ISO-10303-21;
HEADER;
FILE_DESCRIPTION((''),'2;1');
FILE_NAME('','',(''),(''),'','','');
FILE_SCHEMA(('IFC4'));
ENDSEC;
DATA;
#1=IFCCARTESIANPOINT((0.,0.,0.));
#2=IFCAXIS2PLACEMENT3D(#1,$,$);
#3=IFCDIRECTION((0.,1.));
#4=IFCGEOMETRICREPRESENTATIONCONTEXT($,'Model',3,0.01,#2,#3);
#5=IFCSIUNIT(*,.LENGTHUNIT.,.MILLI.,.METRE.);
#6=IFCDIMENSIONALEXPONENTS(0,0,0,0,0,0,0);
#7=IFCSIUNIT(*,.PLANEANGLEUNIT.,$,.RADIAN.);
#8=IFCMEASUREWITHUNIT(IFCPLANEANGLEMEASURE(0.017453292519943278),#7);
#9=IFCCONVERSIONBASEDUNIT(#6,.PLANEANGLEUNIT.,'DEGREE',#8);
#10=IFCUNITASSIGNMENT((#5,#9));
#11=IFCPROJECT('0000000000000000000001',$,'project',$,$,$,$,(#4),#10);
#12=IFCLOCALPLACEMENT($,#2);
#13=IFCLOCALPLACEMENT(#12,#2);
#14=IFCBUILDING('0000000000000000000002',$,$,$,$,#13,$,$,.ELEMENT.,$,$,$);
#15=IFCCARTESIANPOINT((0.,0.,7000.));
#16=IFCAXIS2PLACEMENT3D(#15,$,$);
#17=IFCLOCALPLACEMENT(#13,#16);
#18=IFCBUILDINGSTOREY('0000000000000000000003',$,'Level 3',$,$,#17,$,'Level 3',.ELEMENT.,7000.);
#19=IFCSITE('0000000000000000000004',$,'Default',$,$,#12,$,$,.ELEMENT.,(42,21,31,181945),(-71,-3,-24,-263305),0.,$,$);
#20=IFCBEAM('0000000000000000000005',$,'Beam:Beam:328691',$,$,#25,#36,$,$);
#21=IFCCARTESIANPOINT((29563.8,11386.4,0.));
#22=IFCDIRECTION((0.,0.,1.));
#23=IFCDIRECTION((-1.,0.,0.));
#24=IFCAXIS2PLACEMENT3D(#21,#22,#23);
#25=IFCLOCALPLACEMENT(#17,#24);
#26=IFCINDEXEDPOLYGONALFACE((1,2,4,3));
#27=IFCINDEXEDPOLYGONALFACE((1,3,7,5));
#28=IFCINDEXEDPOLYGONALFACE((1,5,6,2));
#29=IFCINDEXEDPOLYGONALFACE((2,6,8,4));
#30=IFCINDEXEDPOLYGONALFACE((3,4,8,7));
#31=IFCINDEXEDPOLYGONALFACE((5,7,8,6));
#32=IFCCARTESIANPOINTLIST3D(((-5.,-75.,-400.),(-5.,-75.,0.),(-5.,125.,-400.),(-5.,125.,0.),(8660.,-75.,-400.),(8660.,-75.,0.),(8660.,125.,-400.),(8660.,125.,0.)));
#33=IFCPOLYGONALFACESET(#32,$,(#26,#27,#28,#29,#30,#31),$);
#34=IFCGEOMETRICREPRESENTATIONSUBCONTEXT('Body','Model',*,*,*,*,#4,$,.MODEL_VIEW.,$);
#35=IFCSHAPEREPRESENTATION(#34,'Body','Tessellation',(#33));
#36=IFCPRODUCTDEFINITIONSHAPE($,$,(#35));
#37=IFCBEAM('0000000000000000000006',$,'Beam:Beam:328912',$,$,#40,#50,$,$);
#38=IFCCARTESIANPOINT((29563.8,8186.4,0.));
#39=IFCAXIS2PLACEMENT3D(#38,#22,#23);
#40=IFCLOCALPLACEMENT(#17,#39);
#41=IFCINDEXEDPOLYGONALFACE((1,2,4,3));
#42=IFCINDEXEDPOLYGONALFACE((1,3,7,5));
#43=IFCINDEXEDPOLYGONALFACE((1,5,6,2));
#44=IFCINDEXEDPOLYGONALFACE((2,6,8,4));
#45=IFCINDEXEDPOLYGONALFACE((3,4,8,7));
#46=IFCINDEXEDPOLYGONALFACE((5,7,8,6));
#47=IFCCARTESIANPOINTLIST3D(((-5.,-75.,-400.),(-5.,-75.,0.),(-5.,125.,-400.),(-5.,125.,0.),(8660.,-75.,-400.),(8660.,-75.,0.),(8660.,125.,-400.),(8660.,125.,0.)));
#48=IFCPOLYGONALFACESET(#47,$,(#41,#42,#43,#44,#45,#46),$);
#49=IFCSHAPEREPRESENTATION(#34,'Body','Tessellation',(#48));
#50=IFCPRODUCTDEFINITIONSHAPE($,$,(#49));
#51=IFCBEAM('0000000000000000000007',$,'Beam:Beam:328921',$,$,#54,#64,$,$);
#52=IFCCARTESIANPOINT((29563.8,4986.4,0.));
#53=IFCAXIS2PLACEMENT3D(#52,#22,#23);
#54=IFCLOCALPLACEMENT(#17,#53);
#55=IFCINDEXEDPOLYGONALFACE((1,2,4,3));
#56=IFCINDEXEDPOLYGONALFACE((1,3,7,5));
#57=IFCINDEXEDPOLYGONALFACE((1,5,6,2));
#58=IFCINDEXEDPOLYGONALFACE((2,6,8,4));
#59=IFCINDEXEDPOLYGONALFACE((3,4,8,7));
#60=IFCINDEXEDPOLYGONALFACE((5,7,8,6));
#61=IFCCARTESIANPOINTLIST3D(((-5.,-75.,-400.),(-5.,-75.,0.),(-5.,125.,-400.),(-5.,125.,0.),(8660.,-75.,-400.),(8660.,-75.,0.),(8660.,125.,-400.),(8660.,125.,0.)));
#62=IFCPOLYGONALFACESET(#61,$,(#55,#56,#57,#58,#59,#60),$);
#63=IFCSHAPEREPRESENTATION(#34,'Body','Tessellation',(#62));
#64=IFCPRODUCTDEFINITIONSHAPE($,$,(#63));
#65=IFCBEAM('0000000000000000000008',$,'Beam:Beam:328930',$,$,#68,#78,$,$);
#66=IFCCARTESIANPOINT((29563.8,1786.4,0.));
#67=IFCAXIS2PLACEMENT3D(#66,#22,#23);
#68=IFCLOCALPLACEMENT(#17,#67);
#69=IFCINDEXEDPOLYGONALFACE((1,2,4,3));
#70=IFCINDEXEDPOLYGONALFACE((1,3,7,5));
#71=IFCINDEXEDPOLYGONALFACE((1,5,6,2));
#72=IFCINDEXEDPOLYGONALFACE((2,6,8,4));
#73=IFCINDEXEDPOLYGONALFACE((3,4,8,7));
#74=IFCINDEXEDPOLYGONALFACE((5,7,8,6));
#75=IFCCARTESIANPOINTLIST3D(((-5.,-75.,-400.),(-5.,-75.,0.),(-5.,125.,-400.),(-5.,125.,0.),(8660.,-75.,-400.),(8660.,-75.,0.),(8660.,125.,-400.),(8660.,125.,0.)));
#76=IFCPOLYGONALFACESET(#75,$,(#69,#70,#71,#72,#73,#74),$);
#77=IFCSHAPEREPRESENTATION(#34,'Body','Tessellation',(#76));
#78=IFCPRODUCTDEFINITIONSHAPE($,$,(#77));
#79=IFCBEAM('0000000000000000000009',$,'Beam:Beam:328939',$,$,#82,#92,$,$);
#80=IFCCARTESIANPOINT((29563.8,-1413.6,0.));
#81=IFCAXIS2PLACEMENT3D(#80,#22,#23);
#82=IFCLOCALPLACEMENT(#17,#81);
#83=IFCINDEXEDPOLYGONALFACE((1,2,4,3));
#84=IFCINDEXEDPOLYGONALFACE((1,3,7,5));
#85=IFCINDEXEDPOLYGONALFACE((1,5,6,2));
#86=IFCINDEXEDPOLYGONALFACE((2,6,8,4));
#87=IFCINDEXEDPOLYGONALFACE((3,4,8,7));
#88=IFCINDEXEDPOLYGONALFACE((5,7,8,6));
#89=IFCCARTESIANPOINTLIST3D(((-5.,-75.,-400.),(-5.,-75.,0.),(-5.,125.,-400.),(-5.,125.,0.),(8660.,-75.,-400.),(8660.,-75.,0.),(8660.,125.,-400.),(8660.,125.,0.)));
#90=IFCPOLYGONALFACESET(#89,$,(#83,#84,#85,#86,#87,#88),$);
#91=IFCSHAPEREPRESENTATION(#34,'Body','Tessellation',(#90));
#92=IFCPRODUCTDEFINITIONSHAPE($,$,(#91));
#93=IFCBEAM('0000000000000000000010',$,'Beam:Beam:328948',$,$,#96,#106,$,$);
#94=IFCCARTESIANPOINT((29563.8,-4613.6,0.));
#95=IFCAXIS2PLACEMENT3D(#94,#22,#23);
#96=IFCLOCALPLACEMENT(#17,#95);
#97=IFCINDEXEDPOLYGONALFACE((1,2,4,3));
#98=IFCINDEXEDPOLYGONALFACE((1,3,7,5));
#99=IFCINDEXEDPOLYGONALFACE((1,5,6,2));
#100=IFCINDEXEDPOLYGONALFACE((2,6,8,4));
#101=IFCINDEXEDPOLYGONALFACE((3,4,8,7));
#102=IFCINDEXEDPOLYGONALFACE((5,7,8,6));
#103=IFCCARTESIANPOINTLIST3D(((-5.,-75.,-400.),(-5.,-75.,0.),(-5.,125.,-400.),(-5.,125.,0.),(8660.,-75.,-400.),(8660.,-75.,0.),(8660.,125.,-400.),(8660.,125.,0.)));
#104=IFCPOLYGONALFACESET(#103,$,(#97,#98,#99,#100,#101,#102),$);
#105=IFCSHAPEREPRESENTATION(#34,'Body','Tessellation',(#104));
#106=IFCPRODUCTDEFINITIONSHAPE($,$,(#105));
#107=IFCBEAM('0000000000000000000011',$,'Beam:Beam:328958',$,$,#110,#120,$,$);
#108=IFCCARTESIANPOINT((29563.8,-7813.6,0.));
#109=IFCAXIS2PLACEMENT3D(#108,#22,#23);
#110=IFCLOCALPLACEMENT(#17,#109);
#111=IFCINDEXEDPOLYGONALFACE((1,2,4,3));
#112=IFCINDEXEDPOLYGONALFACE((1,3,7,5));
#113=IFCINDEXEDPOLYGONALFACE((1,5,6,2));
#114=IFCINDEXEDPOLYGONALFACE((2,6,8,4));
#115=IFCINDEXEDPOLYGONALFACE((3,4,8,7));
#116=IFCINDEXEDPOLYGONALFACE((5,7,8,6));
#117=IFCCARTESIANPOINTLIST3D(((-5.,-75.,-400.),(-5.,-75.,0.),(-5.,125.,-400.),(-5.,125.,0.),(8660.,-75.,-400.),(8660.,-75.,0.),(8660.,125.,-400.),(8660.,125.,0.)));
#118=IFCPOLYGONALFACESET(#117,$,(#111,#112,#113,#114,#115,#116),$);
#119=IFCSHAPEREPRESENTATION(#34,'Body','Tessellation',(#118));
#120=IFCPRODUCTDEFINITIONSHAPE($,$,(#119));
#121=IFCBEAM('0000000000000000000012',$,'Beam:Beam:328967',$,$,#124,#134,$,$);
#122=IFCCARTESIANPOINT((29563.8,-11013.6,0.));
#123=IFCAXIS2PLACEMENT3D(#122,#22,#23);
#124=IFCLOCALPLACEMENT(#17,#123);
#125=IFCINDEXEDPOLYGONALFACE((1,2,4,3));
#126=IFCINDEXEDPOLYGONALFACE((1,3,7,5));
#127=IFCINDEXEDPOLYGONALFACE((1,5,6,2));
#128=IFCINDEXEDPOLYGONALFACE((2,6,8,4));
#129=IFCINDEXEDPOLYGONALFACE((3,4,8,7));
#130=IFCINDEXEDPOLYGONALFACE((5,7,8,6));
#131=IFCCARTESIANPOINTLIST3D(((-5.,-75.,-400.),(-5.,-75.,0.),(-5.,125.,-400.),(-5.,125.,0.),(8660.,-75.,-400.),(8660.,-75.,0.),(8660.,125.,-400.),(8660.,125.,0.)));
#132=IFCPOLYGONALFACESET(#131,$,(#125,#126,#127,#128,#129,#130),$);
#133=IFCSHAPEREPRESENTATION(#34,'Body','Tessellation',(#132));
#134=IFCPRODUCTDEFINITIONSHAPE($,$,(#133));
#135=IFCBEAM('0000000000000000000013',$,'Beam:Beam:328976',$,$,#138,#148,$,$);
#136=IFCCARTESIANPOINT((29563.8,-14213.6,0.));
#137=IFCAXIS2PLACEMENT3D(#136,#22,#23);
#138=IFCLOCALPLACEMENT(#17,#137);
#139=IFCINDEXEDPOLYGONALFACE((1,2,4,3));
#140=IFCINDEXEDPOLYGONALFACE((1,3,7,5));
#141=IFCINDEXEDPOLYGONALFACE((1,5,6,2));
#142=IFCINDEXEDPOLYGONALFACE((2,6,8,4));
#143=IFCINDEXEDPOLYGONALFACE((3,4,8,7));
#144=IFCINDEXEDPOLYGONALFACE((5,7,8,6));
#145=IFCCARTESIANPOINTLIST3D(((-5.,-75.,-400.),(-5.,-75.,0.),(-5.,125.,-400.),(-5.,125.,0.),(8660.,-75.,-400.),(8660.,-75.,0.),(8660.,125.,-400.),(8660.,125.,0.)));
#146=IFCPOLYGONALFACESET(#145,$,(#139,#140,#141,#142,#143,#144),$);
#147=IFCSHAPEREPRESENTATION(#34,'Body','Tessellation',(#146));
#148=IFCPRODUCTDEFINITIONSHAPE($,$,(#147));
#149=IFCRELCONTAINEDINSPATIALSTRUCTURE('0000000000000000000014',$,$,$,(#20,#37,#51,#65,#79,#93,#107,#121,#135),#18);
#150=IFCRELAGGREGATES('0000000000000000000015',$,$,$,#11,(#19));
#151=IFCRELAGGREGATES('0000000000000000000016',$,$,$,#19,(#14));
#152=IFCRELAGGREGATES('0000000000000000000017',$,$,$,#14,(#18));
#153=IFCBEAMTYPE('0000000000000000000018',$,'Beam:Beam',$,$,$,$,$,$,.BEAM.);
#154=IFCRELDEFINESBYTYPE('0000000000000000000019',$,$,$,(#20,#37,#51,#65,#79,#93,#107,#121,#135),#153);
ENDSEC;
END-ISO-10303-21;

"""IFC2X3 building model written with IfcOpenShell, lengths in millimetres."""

from ifc_helpers import new_model, entity, si_unit, converted_unit, direction, frame, frame_2d, origin, origin_2d_with_axis, place, context, subcontext, project, spatial, rectangle, extrude, type_object, element, save


model = new_model("IFC2X3")

# Units and contexts
model_context = context("Model", 3, precision=0.01, world=origin(), true_north=direction((0.0, 1.0)))
body_context = subcontext(model_context, "Body", "Model", "MODEL_VIEW")
ifc_project = project(units=[si_unit("LENGTHUNIT", "METRE", prefix="MILLI"), converted_unit("PLANEANGLEUNIT", "DEGREE", entity("IfcPlaneAngleMeasure", 0.017453292519943278), si_unit("PLANEANGLEUNIT", "RADIAN"), dimensions=[0, 0, 0, 0, 0, 0, 0])], contexts=[model_context])

# Site, building, storey
site_placement = place(None, origin())
site = spatial("IfcSite", under=ifc_project, at=site_placement, Name="Default", CompositionType="ELEMENT", RefLatitude=(42, 21, 31, 181945), RefLongitude=(-71, -3, -24, -263305), RefElevation=0.0)
building_placement = place(site_placement, origin())
building = spatial("IfcBuilding", under=site, at=building_placement, CompositionType="ELEMENT")
storey_placement = place(building_placement, frame((0.0, 0.0, 7000.0)))
storey = spatial("IfcBuildingStorey", under=building, at=storey_placement, Name="Level 3", LongName="Level 3", CompositionType="ELEMENT", Elevation=7000.0)

# Beams
beam_type = type_object("IfcBeamType", Name="Beam:Beam", PredefinedType="BEAM")
beam_1_placement = place(storey_placement, frame((29563.8, 11386.4, 0.0), z_axis=(0.0, 0.0, 1.0), x_axis=(-1.0, 0.0, 0.0)))
element("IfcBeam", 1, at=beam_1_placement, inside=storey, type_object=beam_type, Name="Beam:Beam:328691", context=body_context, shape_type="SweptSolid", body=[
    extrude(rectangle(XDim=400.0, YDim=200.0, at=frame_2d((0.0, 0.0), x_axis=(1.0, 0.0))), frame((-5.0, 25.0, -200.0), z_axis=(1.0, 0.0, 0.0), x_axis=(0.0, 0.0, -1.0)), (0.0, 0.0, 1.0), 8665.0),
])
beam_2_placement = place(storey_placement, frame((29563.8, 8186.4, 0.0), z_axis=(0.0, 0.0, 1.0), x_axis=(-1.0, 0.0, 0.0)))
element("IfcBeam", 2, at=beam_2_placement, inside=storey, type_object=beam_type, Name="Beam:Beam:328912", context=body_context, shape_type="SweptSolid", body=[
    extrude(rectangle(XDim=400.0, YDim=200.0, at=origin_2d_with_axis()), frame((-5.0, 25.0, -200.0), z_axis=(1.0, 0.0, 0.0), x_axis=(0.0, 0.0, -1.0)), (0.0, 0.0, 1.0), 8665.0),
])
beam_3_placement = place(storey_placement, frame((29563.8, 4986.4, 0.0), z_axis=(0.0, 0.0, 1.0), x_axis=(-1.0, 0.0, 0.0)))
element("IfcBeam", 3, at=beam_3_placement, inside=storey, type_object=beam_type, Name="Beam:Beam:328921", context=body_context, shape_type="SweptSolid", body=[
    extrude(rectangle(XDim=400.0, YDim=200.0, at=origin_2d_with_axis()), frame((-5.0, 25.0, -200.0), z_axis=(1.0, 0.0, 0.0), x_axis=(0.0, 0.0, -1.0)), (0.0, 0.0, 1.0), 8665.0),
])
beam_4_placement = place(storey_placement, frame((29563.8, 1786.4, 0.0), z_axis=(0.0, 0.0, 1.0), x_axis=(-1.0, 0.0, 0.0)))
element("IfcBeam", 4, at=beam_4_placement, inside=storey, type_object=beam_type, Name="Beam:Beam:328930", context=body_context, shape_type="SweptSolid", body=[
    extrude(rectangle(XDim=400.0, YDim=200.0, at=frame_2d((0.0, 0.0), x_axis=(1.0, 0.0))), frame((-5.0, 25.0, -200.0), z_axis=(1.0, 0.0, 0.0), x_axis=(0.0, 0.0, -1.0)), (0.0, 0.0, 1.0), 8665.0),
])
beam_5_placement = place(storey_placement, frame((29563.8, -1413.6, 0.0), z_axis=(0.0, 0.0, 1.0), x_axis=(-1.0, 0.0, 0.0)))
element("IfcBeam", 5, at=beam_5_placement, inside=storey, type_object=beam_type, Name="Beam:Beam:328939", context=body_context, shape_type="SweptSolid", body=[
    extrude(rectangle(XDim=400.0, YDim=200.0, at=frame_2d((0.0, 0.0), x_axis=(1.0, 0.0))), frame((-5.0, 25.0, -200.0), z_axis=(1.0, 0.0, 0.0), x_axis=(0.0, 0.0, -1.0)), (0.0, 0.0, 1.0), 8665.0),
])
beam_6_placement = place(storey_placement, frame((29563.8, -4613.6, 0.0), z_axis=(0.0, 0.0, 1.0), x_axis=(-1.0, 0.0, 0.0)))
element("IfcBeam", 6, at=beam_6_placement, inside=storey, type_object=beam_type, Name="Beam:Beam:328948", context=body_context, shape_type="SweptSolid", body=[
    extrude(rectangle(XDim=400.0, YDim=200.0, at=frame_2d((0.0, 0.0), x_axis=(1.0, 0.0))), frame((-5.0, 25.0, -200.0), z_axis=(1.0, 0.0, 0.0), x_axis=(0.0, 0.0, -1.0)), (0.0, 0.0, 1.0), 8665.0),
])
beam_7_placement = place(storey_placement, frame((29563.8, -7813.6, 0.0), z_axis=(0.0, 0.0, 1.0), x_axis=(-1.0, 0.0, 0.0)))
element("IfcBeam", 7, at=beam_7_placement, inside=storey, type_object=beam_type, Name="Beam:Beam:328958", context=body_context, shape_type="SweptSolid", body=[
    extrude(rectangle(XDim=400.0, YDim=200.0, at=frame_2d((0.0, 0.0), x_axis=(1.0, 0.0))), frame((-5.0, 25.0, -200.0), z_axis=(1.0, 0.0, 0.0), x_axis=(0.0, 0.0, -1.0)), (0.0, 0.0, 1.0), 8665.0),
])
beam_8_placement = place(storey_placement, frame((29563.8, -11013.6, 0.0), z_axis=(0.0, 0.0, 1.0), x_axis=(-1.0, 0.0, 0.0)))
element("IfcBeam", 8, at=beam_8_placement, inside=storey, type_object=beam_type, Name="Beam:Beam:328967", context=body_context, shape_type="SweptSolid", body=[
    extrude(rectangle(XDim=400.0, YDim=200.0, at=frame_2d((0.0, 0.0), x_axis=(1.0, 0.0))), frame((-5.0, 25.0, -200.0), z_axis=(1.0, 0.0, 0.0), x_axis=(0.0, 0.0, -1.0)), (0.0, 0.0, 1.0), 8665.0),
])
beam_9_placement = place(storey_placement, frame((29563.8, -14213.6, 0.0), z_axis=(0.0, 0.0, 1.0), x_axis=(-1.0, 0.0, 0.0)))
element("IfcBeam", 9, at=beam_9_placement, inside=storey, type_object=beam_type, Name="Beam:Beam:328976", context=body_context, shape_type="SweptSolid", body=[
    extrude(rectangle(XDim=400.0, YDim=200.0, at=frame_2d((0.0, 0.0), x_axis=(1.0, 0.0))), frame((-5.0, 25.0, -200.0), z_axis=(1.0, 0.0, 0.0), x_axis=(0.0, 0.0, -1.0)), (0.0, 0.0, 1.0), 8665.0),
])

save(model, "model.ifc")
